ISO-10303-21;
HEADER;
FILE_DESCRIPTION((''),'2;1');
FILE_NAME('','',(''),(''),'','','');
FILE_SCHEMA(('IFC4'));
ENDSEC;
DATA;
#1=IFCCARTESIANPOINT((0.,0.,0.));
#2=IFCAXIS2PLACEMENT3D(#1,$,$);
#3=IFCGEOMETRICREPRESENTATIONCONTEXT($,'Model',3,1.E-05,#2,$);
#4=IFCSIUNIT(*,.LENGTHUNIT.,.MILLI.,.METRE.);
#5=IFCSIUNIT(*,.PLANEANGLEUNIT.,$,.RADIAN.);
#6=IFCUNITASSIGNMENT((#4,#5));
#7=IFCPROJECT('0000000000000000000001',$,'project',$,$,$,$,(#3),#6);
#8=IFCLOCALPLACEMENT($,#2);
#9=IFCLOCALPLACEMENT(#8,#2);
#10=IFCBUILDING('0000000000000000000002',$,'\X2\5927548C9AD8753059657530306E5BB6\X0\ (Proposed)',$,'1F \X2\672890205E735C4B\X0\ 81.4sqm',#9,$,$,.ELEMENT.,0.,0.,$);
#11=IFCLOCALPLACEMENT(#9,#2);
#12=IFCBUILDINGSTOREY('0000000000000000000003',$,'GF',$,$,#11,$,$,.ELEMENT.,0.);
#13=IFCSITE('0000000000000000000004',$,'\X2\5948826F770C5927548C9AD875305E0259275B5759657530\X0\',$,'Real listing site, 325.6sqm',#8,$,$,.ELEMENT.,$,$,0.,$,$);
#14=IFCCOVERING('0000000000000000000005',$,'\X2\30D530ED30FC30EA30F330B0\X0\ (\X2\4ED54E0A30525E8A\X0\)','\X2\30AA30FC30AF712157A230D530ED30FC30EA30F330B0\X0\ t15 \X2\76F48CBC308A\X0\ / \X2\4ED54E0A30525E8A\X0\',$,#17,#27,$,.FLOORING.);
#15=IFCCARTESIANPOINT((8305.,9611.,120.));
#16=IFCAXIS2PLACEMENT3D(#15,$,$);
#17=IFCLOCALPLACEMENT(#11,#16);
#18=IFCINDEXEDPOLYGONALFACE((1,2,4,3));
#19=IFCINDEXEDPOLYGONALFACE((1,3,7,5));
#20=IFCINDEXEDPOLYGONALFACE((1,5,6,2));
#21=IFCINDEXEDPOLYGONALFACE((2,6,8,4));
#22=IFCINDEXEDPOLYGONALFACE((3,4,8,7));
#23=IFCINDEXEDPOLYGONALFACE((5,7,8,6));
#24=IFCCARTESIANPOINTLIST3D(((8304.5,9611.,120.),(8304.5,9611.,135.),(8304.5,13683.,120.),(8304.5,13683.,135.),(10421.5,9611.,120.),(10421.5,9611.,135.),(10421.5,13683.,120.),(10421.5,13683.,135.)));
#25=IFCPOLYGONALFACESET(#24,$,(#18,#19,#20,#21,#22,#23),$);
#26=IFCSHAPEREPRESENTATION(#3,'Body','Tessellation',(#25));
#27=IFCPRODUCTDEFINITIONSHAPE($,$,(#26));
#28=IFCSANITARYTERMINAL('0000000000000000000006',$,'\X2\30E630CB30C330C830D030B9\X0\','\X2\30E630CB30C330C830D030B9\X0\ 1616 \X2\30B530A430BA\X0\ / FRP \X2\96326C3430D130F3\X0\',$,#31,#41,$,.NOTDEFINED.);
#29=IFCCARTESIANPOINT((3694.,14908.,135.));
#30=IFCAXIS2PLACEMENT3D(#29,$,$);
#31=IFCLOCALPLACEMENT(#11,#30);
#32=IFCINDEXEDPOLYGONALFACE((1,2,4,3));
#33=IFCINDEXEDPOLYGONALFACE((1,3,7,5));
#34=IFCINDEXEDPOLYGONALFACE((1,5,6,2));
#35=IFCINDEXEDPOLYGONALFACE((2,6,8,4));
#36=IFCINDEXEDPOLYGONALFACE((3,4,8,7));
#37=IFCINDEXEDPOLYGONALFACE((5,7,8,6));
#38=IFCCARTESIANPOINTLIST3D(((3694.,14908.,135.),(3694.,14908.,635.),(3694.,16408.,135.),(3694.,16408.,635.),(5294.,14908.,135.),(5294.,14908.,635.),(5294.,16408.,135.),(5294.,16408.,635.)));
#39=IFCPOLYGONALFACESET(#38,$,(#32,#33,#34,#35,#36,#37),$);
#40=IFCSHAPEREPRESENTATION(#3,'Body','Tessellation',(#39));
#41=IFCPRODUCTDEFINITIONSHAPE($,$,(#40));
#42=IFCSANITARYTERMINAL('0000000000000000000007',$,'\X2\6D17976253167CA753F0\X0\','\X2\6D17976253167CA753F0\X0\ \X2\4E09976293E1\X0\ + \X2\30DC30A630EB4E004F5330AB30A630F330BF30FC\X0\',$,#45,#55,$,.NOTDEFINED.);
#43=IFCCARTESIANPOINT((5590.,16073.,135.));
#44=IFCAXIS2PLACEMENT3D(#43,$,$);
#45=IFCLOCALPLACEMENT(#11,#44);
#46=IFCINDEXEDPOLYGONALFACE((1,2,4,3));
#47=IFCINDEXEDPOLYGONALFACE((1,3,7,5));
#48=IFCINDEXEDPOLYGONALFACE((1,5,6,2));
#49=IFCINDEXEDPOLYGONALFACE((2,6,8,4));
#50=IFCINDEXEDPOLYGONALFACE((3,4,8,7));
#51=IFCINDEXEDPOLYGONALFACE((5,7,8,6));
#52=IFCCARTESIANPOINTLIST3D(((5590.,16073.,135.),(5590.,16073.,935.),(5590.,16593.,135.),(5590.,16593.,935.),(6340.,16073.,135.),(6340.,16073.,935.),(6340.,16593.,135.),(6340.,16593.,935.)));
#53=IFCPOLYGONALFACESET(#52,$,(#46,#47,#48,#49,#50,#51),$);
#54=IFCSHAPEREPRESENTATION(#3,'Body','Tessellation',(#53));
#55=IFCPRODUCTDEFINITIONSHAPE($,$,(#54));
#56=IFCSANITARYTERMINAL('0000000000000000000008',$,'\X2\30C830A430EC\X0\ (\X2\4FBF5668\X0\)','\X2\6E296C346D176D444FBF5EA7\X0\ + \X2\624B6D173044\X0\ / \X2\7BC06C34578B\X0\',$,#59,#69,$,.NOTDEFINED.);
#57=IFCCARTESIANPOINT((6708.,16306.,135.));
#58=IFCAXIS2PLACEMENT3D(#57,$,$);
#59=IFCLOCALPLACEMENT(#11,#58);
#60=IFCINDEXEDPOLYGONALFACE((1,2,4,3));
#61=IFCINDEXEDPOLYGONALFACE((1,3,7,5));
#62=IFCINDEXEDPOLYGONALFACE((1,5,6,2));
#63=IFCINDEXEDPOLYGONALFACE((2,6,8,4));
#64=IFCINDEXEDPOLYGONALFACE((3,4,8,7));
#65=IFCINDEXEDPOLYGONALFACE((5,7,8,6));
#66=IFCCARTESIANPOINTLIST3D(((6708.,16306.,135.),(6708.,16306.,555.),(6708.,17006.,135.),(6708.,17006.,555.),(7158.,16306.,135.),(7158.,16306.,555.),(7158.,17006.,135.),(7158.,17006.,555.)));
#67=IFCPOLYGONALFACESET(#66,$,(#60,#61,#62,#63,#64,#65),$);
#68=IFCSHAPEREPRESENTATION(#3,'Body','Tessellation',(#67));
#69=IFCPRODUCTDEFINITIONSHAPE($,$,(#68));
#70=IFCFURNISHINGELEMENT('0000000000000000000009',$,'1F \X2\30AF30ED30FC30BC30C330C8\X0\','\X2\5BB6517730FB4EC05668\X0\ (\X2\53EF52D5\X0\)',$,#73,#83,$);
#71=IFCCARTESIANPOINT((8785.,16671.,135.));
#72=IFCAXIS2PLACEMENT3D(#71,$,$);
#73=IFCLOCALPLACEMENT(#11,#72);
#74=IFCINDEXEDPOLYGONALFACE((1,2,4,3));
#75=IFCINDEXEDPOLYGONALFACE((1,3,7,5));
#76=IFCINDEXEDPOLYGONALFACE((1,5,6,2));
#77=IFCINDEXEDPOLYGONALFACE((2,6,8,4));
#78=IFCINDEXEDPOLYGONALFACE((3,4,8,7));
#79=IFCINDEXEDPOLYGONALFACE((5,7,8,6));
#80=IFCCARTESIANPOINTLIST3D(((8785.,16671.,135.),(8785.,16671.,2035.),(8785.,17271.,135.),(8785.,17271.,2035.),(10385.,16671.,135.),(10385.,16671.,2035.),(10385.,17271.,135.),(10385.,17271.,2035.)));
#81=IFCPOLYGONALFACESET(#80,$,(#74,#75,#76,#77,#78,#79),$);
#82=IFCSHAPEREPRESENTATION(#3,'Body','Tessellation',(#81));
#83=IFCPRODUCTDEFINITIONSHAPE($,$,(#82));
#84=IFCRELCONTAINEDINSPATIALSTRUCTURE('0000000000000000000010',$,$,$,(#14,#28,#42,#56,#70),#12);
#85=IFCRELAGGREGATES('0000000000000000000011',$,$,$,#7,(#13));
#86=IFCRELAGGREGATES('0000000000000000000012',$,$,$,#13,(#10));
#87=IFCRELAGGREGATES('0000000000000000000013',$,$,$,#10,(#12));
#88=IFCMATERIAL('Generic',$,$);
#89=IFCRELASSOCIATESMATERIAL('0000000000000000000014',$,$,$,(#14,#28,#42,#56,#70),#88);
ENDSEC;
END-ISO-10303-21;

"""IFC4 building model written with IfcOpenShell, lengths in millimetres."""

from ifc_helpers import new_model, si_unit, frame, frame_2d, origin, place, context, project, spatial, rectangle, extrude, material, element, save


model = new_model("IFC4")

# Units and contexts
model_context = context("Model", 3, precision=1e-05, world=origin())
ifc_project = project(units=[si_unit("LENGTHUNIT", "METRE", prefix="MILLI"), si_unit("PLANEANGLEUNIT", "RADIAN")], contexts=[model_context])

# Site, building, storey
site_placement = place(None, origin())
site = spatial("IfcSite", under=ifc_project, at=site_placement, Name="奈良県大和高田市大字奥田", ObjectType="Real listing site, 325.6sqm", CompositionType="ELEMENT", RefElevation=0.0)
building_placement = place(site_placement, origin())
building = spatial("IfcBuilding", under=site, at=building_placement, Name="大和高田奥田の家 (Proposed)", ObjectType="1F 木造平屋 81.4sqm", CompositionType="ELEMENT", ElevationOfRefHeight=0.0, ElevationOfTerrain=0.0)
storey_placement = place(building_placement, origin())
storey = spatial("IfcBuildingStorey", under=building, at=storey_placement, Name="GF", CompositionType="ELEMENT", Elevation=0.0)

# Covering
ifc_material_1 = material(Name="Generic")
covering_1_placement = place(storey_placement, frame((8305.0, 9611.0, 120.0)))
element("IfcCovering", 1, at=covering_1_placement, inside=storey, material=ifc_material_1, Name="フローリング (仕上げ床)", Description="オーク無垢フローリング t15 直貼り / 仕上げ床", PredefinedType="FLOORING", context=model_context, shape_type="SweptSolid", body=[
    extrude(rectangle(XDim=2117.0, YDim=4072.0, at=frame_2d((1058.0, 2036.0))), frame((8305.0, 9611.0, 120.0)), (0.0, 0.0, 1.0), 15.0),
])

# Sanitary terminals
sanitary_terminal_1_placement = place(storey_placement, frame((3694.0, 14908.0, 135.0)))
element("IfcSanitaryTerminal", 2, at=sanitary_terminal_1_placement, inside=storey, material=ifc_material_1, Name="ユニットバス", Description="ユニットバス 1616 サイズ / FRP 防水パン", PredefinedType="NOTDEFINED", context=model_context, shape_type="SweptSolid", body=[
    extrude(rectangle(XDim=1600.0, YDim=1500.0, at=frame_2d((800.0, 750.0))), frame((3694.0, 14908.0, 135.0)), (0.0, 0.0, 1.0), 500.0),
])
sanitary_terminal_2_placement = place(storey_placement, frame((5590.0, 16073.0, 135.0)))
element("IfcSanitaryTerminal", 3, at=sanitary_terminal_2_placement, inside=storey, material=ifc_material_1, Name="洗面化粧台", Description="洗面化粧台 三面鏡 + ボウル一体カウンター", PredefinedType="NOTDEFINED", context=model_context, shape_type="SweptSolid", body=[
    extrude(rectangle(XDim=750.0, YDim=520.0, at=frame_2d((375.0, 260.0))), frame((5590.0, 16073.0, 135.0)), (0.0, 0.0, 1.0), 800.0),
])
sanitary_terminal_3_placement = place(storey_placement, frame((6708.0, 16306.0, 135.0)))
element("IfcSanitaryTerminal", 4, at=sanitary_terminal_3_placement, inside=storey, material=ifc_material_1, Name="トイレ (便器)", Description="温水洗浄便座 + 手洗い / 節水型", PredefinedType="NOTDEFINED", context=model_context, shape_type="SweptSolid", body=[
    extrude(rectangle(XDim=450.0, YDim=700.0, at=frame_2d((225.0, 350.0))), frame((6708.0, 16306.0, 135.0)), (0.0, 0.0, 1.0), 420.0),
])

# Furnishing element
furnishing_placement = place(storey_placement, frame((8785.0, 16671.0, 135.0)))
element("IfcFurnishingElement", 5, at=furnishing_placement, inside=storey, material=ifc_material_1, Name="1F クローゼット", Description="家具・什器 (可動)", context=model_context, shape_type="SweptSolid", body=[
    extrude(rectangle(XDim=1600.0, YDim=600.0, at=frame_2d((800.0, 300.0))), frame((8785.0, 16671.0, 135.0)), (0.0, 0.0, 1.0), 1900.0),
])

save(model, "model.ifc")
